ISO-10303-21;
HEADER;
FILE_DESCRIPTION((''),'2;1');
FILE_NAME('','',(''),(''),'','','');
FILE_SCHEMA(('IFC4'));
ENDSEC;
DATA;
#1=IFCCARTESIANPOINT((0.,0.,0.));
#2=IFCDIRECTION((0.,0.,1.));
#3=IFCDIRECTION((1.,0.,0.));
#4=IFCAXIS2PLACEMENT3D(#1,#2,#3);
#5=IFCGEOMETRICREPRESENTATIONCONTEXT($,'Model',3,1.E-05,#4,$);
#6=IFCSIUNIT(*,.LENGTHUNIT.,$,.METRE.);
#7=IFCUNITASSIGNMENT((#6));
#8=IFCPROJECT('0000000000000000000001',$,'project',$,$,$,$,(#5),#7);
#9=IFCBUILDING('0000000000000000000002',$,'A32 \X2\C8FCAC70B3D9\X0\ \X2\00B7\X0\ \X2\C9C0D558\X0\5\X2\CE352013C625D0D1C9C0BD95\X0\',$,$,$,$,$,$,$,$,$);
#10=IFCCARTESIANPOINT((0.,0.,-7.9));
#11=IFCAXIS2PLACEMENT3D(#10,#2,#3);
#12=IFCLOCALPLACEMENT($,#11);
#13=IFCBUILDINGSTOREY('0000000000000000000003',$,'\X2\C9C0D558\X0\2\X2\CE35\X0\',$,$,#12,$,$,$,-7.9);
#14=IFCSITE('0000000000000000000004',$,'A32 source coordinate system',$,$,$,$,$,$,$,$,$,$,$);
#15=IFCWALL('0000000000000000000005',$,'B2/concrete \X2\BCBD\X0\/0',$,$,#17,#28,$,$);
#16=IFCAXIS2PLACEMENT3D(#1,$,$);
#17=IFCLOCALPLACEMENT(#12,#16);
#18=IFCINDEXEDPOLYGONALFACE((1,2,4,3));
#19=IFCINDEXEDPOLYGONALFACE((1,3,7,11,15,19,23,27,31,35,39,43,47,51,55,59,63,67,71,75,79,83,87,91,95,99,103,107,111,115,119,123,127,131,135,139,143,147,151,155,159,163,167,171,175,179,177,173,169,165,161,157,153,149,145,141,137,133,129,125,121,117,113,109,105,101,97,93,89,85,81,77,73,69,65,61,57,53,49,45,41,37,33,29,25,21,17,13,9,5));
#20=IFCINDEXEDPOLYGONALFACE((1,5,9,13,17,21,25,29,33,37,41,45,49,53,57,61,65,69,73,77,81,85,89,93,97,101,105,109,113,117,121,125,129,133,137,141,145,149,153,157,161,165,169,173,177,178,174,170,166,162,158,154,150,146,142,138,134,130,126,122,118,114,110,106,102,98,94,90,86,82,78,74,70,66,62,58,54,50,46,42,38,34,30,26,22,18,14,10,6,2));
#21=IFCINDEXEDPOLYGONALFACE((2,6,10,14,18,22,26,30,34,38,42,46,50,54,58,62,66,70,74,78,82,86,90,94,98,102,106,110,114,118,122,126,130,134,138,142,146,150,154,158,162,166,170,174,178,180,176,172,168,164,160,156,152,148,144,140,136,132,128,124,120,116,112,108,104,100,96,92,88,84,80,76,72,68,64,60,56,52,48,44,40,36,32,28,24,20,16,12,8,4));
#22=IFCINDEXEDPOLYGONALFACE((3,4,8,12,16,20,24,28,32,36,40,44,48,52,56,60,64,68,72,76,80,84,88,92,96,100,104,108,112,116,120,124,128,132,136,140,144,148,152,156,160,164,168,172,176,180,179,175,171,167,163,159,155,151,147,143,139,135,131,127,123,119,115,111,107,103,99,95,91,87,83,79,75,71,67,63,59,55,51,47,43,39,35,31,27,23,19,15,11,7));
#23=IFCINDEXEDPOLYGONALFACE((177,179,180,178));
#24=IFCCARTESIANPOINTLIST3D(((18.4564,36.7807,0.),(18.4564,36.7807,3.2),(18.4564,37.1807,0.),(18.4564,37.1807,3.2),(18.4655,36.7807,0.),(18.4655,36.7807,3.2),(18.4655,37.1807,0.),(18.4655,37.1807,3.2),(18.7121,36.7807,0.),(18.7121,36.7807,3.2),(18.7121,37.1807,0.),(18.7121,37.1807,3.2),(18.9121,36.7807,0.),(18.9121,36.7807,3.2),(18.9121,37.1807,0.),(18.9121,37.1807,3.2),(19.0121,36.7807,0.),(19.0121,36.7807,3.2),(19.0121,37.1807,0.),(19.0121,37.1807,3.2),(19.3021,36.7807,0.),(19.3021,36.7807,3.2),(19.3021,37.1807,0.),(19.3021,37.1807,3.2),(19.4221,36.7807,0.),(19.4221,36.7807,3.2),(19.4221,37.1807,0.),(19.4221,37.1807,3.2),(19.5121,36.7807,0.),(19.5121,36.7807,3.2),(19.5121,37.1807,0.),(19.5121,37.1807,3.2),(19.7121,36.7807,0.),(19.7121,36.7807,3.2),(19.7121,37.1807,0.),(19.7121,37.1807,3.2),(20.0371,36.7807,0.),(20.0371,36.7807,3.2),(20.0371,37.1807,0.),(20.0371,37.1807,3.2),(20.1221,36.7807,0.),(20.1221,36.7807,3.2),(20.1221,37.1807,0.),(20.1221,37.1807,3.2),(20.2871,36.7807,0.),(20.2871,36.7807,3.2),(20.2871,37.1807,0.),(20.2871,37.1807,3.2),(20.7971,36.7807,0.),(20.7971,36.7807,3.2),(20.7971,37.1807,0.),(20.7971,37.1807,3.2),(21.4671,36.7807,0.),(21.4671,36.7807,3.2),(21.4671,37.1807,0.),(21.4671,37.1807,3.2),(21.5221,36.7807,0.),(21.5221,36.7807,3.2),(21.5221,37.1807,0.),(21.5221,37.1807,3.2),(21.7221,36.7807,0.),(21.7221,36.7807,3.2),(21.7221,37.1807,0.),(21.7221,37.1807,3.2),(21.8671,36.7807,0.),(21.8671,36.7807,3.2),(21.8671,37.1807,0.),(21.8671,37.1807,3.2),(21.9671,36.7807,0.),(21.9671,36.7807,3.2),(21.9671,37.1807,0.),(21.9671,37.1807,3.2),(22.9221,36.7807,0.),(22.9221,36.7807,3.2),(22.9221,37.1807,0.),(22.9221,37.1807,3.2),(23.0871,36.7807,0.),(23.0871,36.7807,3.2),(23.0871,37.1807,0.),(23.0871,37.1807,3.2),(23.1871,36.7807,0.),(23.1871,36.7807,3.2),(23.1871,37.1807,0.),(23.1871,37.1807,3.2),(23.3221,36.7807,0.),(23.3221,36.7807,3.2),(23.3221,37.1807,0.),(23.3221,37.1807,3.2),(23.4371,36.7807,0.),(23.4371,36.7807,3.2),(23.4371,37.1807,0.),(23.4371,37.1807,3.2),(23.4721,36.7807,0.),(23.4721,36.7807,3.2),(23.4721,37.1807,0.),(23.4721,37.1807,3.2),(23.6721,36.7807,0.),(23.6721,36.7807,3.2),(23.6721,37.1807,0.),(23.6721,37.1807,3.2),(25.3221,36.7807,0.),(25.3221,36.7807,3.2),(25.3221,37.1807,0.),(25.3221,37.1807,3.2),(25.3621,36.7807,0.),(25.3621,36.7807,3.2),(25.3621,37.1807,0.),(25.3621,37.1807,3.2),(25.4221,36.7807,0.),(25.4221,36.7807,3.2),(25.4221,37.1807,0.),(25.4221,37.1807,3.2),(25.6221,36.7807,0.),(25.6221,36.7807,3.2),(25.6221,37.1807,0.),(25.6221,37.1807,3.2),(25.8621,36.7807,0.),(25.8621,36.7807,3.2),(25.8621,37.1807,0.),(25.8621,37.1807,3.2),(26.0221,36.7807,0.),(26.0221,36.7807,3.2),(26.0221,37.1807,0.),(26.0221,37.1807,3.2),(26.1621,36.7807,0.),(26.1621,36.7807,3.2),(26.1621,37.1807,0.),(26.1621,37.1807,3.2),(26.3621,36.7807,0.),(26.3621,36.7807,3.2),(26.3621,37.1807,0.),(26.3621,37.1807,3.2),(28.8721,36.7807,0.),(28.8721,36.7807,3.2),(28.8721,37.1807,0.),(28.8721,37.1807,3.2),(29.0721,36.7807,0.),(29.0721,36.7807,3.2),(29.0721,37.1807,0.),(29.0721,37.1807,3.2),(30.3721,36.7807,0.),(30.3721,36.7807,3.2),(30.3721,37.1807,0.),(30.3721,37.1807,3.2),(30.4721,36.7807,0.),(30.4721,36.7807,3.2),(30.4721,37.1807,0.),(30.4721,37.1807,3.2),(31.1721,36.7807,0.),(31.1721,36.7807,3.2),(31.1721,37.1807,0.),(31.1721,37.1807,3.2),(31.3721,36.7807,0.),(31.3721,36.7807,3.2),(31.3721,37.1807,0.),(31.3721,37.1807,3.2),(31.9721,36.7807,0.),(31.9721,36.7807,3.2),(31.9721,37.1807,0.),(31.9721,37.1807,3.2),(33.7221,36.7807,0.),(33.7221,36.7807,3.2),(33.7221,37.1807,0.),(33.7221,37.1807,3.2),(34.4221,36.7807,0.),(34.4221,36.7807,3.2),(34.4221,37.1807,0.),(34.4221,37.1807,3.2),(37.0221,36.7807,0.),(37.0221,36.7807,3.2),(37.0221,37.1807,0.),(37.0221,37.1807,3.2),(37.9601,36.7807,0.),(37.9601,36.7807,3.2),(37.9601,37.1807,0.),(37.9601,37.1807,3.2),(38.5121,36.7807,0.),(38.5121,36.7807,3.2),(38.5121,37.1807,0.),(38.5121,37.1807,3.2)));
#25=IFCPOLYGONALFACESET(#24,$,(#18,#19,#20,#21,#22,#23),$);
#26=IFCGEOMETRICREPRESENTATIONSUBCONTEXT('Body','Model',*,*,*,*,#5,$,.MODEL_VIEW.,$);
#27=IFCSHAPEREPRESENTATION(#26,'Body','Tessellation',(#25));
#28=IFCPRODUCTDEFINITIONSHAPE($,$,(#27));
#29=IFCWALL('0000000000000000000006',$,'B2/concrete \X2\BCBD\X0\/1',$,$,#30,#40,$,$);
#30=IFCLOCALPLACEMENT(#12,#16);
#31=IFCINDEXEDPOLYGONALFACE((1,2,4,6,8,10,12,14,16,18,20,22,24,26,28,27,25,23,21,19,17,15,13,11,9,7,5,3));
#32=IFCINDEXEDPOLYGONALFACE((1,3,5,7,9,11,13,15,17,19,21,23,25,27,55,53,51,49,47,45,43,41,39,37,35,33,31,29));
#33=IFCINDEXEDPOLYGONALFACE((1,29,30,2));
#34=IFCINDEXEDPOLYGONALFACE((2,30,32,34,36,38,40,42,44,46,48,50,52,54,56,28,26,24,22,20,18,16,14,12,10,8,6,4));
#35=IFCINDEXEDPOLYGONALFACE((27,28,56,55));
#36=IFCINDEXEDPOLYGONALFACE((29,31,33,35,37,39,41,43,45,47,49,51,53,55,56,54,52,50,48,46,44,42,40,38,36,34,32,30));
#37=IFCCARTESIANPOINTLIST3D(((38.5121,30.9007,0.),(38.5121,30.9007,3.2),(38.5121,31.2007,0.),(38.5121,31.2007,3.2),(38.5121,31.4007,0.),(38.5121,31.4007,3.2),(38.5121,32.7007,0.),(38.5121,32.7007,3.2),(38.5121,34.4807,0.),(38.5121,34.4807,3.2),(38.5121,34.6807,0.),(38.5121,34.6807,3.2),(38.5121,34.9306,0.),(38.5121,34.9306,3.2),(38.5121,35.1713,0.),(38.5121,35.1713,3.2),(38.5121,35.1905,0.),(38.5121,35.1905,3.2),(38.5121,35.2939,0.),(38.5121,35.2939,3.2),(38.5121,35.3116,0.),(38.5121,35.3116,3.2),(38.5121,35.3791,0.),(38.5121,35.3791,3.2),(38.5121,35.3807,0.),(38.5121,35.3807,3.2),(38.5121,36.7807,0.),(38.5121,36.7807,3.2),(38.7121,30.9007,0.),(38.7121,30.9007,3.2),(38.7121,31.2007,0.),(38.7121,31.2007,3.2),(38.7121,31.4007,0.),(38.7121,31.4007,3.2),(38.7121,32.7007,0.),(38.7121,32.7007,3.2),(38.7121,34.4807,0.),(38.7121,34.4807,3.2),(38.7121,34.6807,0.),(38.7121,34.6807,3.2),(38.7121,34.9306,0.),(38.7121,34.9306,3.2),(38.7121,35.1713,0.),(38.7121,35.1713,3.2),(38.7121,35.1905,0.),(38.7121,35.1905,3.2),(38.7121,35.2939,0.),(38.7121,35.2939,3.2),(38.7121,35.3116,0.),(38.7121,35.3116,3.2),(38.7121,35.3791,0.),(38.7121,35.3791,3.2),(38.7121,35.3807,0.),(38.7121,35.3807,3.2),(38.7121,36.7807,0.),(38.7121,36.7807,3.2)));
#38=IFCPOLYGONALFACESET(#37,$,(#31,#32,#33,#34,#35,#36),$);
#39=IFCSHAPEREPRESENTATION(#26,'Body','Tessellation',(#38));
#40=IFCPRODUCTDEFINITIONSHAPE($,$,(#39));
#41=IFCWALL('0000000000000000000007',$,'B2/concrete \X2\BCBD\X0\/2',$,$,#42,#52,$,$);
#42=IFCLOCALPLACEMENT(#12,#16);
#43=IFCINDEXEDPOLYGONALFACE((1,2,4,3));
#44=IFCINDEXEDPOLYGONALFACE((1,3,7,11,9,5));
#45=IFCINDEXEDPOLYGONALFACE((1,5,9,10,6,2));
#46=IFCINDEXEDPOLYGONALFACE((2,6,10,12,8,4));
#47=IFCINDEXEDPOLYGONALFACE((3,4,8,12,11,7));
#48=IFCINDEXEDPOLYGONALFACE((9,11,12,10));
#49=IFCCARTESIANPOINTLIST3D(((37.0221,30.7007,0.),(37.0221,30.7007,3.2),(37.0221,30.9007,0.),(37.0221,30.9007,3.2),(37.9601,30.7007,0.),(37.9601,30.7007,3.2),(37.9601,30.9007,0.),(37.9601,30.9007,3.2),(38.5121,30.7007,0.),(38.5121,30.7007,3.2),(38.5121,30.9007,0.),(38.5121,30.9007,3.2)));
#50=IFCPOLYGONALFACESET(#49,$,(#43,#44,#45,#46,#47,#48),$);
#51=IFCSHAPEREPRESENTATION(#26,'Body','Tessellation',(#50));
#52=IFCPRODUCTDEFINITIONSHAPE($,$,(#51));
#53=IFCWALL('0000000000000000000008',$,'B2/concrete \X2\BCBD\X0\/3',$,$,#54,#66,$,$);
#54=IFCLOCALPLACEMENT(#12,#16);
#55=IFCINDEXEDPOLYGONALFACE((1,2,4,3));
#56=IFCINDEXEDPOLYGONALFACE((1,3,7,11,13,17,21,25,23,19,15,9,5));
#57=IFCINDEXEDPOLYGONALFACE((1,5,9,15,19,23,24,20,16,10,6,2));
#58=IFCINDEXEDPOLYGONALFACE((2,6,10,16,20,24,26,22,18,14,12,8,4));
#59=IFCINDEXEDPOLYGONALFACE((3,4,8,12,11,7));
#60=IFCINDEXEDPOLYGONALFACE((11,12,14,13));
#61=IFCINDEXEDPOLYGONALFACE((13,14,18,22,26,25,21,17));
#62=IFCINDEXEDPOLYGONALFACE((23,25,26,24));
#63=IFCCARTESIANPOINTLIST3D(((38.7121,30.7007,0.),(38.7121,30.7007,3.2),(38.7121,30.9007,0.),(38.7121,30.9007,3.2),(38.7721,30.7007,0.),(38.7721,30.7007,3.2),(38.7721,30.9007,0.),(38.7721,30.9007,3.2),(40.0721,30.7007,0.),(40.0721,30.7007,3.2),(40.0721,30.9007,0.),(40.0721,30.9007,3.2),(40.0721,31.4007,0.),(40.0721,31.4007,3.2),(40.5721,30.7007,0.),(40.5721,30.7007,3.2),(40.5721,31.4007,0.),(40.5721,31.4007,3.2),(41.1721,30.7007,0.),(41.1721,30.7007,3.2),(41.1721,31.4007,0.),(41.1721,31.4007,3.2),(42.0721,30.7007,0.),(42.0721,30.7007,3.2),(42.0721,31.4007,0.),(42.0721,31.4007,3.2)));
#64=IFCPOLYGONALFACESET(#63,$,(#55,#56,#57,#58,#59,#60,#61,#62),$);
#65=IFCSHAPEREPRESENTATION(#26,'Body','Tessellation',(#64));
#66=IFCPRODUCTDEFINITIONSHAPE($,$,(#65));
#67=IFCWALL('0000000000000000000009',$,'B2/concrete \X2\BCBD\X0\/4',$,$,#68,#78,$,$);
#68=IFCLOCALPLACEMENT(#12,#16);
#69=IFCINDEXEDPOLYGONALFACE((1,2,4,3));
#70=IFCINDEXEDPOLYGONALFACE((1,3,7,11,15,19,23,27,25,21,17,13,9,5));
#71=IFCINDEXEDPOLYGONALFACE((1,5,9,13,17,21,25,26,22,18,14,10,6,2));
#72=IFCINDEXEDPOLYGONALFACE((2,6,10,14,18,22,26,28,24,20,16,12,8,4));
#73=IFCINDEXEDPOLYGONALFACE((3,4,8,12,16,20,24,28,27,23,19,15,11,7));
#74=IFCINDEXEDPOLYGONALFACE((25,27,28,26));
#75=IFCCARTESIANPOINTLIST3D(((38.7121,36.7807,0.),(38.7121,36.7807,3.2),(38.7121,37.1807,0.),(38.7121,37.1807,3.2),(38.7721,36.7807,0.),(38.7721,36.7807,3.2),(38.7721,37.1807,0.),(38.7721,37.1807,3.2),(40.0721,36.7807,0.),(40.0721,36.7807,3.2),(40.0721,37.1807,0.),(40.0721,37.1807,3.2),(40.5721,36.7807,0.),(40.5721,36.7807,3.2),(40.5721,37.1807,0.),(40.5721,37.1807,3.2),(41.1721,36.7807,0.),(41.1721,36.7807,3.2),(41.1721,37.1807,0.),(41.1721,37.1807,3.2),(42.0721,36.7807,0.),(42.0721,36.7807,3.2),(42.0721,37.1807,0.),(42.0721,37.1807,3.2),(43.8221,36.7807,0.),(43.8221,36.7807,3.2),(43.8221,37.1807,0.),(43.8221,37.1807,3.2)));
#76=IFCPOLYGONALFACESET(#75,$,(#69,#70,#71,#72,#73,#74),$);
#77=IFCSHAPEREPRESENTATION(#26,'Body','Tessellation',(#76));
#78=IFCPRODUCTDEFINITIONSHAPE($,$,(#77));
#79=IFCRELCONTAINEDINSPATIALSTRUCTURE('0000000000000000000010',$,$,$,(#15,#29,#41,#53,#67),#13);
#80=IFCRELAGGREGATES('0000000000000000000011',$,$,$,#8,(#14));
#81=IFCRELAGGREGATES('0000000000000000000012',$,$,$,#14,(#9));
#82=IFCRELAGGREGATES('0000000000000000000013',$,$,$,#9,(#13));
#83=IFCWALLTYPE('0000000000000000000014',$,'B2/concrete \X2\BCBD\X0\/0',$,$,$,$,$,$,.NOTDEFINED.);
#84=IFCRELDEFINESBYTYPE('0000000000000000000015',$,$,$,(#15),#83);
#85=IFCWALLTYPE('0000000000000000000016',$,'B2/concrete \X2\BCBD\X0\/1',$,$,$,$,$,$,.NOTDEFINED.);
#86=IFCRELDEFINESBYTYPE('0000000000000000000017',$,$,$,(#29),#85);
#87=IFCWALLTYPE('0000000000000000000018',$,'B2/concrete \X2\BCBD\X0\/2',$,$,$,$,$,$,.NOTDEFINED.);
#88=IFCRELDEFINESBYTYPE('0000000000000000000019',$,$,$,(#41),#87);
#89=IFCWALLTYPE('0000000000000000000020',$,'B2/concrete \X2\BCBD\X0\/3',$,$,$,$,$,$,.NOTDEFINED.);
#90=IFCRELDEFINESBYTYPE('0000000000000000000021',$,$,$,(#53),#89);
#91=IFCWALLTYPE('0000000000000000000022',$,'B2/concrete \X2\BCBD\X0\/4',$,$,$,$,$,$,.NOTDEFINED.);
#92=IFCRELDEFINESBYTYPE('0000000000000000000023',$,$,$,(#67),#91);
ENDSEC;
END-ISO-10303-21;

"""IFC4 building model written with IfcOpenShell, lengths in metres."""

from ifc_helpers import new_model, si_unit, frame, origin, origin_with_axes, place, context, subcontext, project, spatial, polyline, outline, extrude, source, transform, mapped, type_object, type_shapes, element, save


model = new_model("IFC4")

# Units and contexts
model_context = context("Model", 3, precision=1e-05, world=origin_with_axes())
body_context = subcontext(model_context, "Body", "Model", "MODEL_VIEW")
ifc_project = project(units=[si_unit("LENGTHUNIT", "METRE")], contexts=[model_context])

# Site, building, storey
site = spatial("IfcSite", under=ifc_project, Name="A32 source coordinate system")
building = spatial("IfcBuilding", under=site, Name="A32 주거동 · 지하5층–옥탑지붕")
storey_placement = place(None, frame((0.0, 0.0, -7.9), z_axis=(0.0, 0.0, 1.0), x_axis=(1.0, 0.0, 0.0)))
storey = spatial("IfcBuildingStorey", under=building, at=storey_placement, Name="지하2층", Elevation=-7.9)

# Walls
wall_type_1 = type_object("IfcWallType", Name="B2/concrete 벽/0", PredefinedType="NOTDEFINED")
shared_shape_1 = source(origin(), body_context, "Body", "SweptSolid", [
    extrude(outline(polyline([(20.1221, 37.1807), (20.2871, 37.1807), (20.7971, 37.1807), (21.4671, 37.1807), (21.5221, 37.1807), (21.7221, 37.1807), (21.8671, 37.1807), (21.9671, 37.1807), (22.9221, 37.1807), (23.0871, 37.1807), (23.1871, 37.1807), (23.3221, 37.1807), (23.4371, 37.1807), (23.4721, 37.1807), (23.6721, 37.1807), (25.3221, 37.1807), (25.3621, 37.1807), (25.4221, 37.1807), (25.6221, 37.1807), (25.8621, 37.1807), (26.0221, 37.1807), (26.1621, 37.1807), (26.3621, 37.1807), (28.8721, 37.1807), (29.0721, 37.1807), (30.3721, 37.1807), (30.4721, 37.1807), (31.1721, 37.1807), (31.3721, 37.1807), (31.9721, 37.1807), (33.7221, 37.1807), (34.4221, 37.1807), (37.0221, 37.1807), (37.9601, 37.1807), (38.5121, 37.1807), (38.5121, 36.7807), (37.9601, 36.7807), (37.0221, 36.7807), (34.4221, 36.7807), (33.7221, 36.7807), (31.9721, 36.7807), (31.3721, 36.7807), (31.1721, 36.7807), (30.4721, 36.7807), (30.3721, 36.7807), (29.0721, 36.7807), (28.8721, 36.7807), (26.3621, 36.7807), (26.1621, 36.7807), (26.0221, 36.7807), (25.8621, 36.7807), (25.6221, 36.7807), (25.4221, 36.7807), (25.3621, 36.7807), (25.3221, 36.7807), (23.6721, 36.7807), (23.4721, 36.7807), (23.4371, 36.7807), (23.3221, 36.7807), (23.1871, 36.7807), (23.0871, 36.7807), (22.9221, 36.7807), (21.9671, 36.7807), (21.8671, 36.7807), (21.7221, 36.7807), (21.5221, 36.7807), (21.4671, 36.7807), (20.7971, 36.7807), (20.2871, 36.7807), (20.1221, 36.7807), (20.0371, 36.7807), (19.7121, 36.7807), (19.5121, 36.7807), (19.4221, 36.7807), (19.3021, 36.7807), (19.0121, 36.7807), (18.9121, 36.7807), (18.7121, 36.7807), (18.4655, 36.7807), (18.4564, 36.7807), (18.4564, 37.1807), (18.4655, 37.1807), (18.7121, 37.1807), (18.9121, 37.1807), (19.0121, 37.1807), (19.3021, 37.1807), (19.4221, 37.1807), (19.5121, 37.1807), (19.7121, 37.1807), (20.0371, 37.1807), (20.1221, 37.1807)])), origin(), (0.0, 0.0, 1.0), 3.2),
])
type_shapes(wall_type_1, [shared_shape_1])
wall_1_placement = place(storey_placement, origin_with_axes())
element("IfcWall", 1, at=wall_1_placement, inside=storey, type_object=wall_type_1, Name="B2/concrete 벽/0", context=body_context, shape_type="MappedRepresentation", body=[
    mapped(shared_shape_1, transform((0.0, 0.0, 0.0), scale=1.0)),
])
wall_type_2 = type_object("IfcWallType", Name="B2/concrete 벽/1", PredefinedType="NOTDEFINED")
shared_shape_2 = source(origin(), body_context, "Body", "SweptSolid", [
    extrude(outline(polyline([(38.7121, 35.3791), (38.7121, 35.3116), (38.7121, 35.2939), (38.7121, 35.1905), (38.7121, 35.1713), (38.7121, 34.9306), (38.7121, 34.6807), (38.7121, 34.4807), (38.7121, 32.7007), (38.7121, 31.4007), (38.7121, 31.2007), (38.7121, 30.9007), (38.5121, 30.9007), (38.5121, 31.2007), (38.5121, 31.4007), (38.5121, 32.7007), (38.5121, 34.4807), (38.5121, 34.6807), (38.5121, 34.9306), (38.5121, 35.1713), (38.5121, 35.1905), (38.5121, 35.2939), (38.5121, 35.3116), (38.5121, 35.3791), (38.5121, 35.3807), (38.5121, 36.7807), (38.7121, 36.7807), (38.7121, 35.3807), (38.7121, 35.3791)])), origin(), (0.0, 0.0, 1.0), 3.2),
])
type_shapes(wall_type_2, [shared_shape_2])
wall_2_placement = place(storey_placement, origin_with_axes())
element("IfcWall", 2, at=wall_2_placement, inside=storey, type_object=wall_type_2, Name="B2/concrete 벽/1", context=body_context, shape_type="MappedRepresentation", body=[
    mapped(shared_shape_2, transform((0.0, 0.0, 0.0), scale=1.0)),
])
wall_type_3 = type_object("IfcWallType", Name="B2/concrete 벽/2", PredefinedType="NOTDEFINED")
shared_shape_3 = source(origin(), body_context, "Body", "SweptSolid", [
    extrude(outline(polyline([(37.0221, 30.7007), (37.0221, 30.9007), (37.9601, 30.9007), (38.5121, 30.9007), (38.5121, 30.7007), (37.9601, 30.7007), (37.0221, 30.7007)])), origin(), (0.0, 0.0, 1.0), 3.2),
])
type_shapes(wall_type_3, [shared_shape_3])
wall_3_placement = place(storey_placement, origin_with_axes())
element("IfcWall", 3, at=wall_3_placement, inside=storey, type_object=wall_type_3, Name="B2/concrete 벽/2", context=body_context, shape_type="MappedRepresentation", body=[
    mapped(shared_shape_3, transform((0.0, 0.0, 0.0), scale=1.0)),
])
wall_type_4 = type_object("IfcWallType", Name="B2/concrete 벽/3", PredefinedType="NOTDEFINED")
shared_shape_4 = source(origin(), body_context, "Body", "SweptSolid", [
    extrude(outline(polyline([(40.0721, 31.4007), (40.5721, 31.4007), (41.1721, 31.4007), (42.0721, 31.4007), (42.0721, 30.7007), (41.1721, 30.7007), (40.5721, 30.7007), (40.0721, 30.7007), (38.7721, 30.7007), (38.7121, 30.7007), (38.7121, 30.9007), (38.7721, 30.9007), (40.0721, 30.9007), (40.0721, 31.4007)])), origin(), (0.0, 0.0, 1.0), 3.2),
])
type_shapes(wall_type_4, [shared_shape_4])
wall_4_placement = place(storey_placement, origin_with_axes())
element("IfcWall", 4, at=wall_4_placement, inside=storey, type_object=wall_type_4, Name="B2/concrete 벽/3", context=body_context, shape_type="MappedRepresentation", body=[
    mapped(shared_shape_4, transform((0.0, 0.0, 0.0), scale=1.0)),
])
wall_type_5 = type_object("IfcWallType", Name="B2/concrete 벽/4", PredefinedType="NOTDEFINED")
shared_shape_5 = source(origin(), body_context, "Body", "SweptSolid", [
    extrude(outline(polyline([(40.0721, 37.1807), (40.5721, 37.1807), (41.1721, 37.1807), (42.0721, 37.1807), (43.8221, 37.1807), (43.8221, 36.7807), (42.0721, 36.7807), (41.1721, 36.7807), (40.5721, 36.7807), (40.0721, 36.7807), (38.7721, 36.7807), (38.7121, 36.7807), (38.7121, 37.1807), (38.7721, 37.1807), (40.0721, 37.1807)])), origin(), (0.0, 0.0, 1.0), 3.2),
])
type_shapes(wall_type_5, [shared_shape_5])
wall_5_placement = place(storey_placement, origin_with_axes())
element("IfcWall", 5, at=wall_5_placement, inside=storey, type_object=wall_type_5, Name="B2/concrete 벽/4", context=body_context, shape_type="MappedRepresentation", body=[
    mapped(shared_shape_5, transform((0.0, 0.0, 0.0), scale=1.0)),
])

save(model, "model.ifc")
